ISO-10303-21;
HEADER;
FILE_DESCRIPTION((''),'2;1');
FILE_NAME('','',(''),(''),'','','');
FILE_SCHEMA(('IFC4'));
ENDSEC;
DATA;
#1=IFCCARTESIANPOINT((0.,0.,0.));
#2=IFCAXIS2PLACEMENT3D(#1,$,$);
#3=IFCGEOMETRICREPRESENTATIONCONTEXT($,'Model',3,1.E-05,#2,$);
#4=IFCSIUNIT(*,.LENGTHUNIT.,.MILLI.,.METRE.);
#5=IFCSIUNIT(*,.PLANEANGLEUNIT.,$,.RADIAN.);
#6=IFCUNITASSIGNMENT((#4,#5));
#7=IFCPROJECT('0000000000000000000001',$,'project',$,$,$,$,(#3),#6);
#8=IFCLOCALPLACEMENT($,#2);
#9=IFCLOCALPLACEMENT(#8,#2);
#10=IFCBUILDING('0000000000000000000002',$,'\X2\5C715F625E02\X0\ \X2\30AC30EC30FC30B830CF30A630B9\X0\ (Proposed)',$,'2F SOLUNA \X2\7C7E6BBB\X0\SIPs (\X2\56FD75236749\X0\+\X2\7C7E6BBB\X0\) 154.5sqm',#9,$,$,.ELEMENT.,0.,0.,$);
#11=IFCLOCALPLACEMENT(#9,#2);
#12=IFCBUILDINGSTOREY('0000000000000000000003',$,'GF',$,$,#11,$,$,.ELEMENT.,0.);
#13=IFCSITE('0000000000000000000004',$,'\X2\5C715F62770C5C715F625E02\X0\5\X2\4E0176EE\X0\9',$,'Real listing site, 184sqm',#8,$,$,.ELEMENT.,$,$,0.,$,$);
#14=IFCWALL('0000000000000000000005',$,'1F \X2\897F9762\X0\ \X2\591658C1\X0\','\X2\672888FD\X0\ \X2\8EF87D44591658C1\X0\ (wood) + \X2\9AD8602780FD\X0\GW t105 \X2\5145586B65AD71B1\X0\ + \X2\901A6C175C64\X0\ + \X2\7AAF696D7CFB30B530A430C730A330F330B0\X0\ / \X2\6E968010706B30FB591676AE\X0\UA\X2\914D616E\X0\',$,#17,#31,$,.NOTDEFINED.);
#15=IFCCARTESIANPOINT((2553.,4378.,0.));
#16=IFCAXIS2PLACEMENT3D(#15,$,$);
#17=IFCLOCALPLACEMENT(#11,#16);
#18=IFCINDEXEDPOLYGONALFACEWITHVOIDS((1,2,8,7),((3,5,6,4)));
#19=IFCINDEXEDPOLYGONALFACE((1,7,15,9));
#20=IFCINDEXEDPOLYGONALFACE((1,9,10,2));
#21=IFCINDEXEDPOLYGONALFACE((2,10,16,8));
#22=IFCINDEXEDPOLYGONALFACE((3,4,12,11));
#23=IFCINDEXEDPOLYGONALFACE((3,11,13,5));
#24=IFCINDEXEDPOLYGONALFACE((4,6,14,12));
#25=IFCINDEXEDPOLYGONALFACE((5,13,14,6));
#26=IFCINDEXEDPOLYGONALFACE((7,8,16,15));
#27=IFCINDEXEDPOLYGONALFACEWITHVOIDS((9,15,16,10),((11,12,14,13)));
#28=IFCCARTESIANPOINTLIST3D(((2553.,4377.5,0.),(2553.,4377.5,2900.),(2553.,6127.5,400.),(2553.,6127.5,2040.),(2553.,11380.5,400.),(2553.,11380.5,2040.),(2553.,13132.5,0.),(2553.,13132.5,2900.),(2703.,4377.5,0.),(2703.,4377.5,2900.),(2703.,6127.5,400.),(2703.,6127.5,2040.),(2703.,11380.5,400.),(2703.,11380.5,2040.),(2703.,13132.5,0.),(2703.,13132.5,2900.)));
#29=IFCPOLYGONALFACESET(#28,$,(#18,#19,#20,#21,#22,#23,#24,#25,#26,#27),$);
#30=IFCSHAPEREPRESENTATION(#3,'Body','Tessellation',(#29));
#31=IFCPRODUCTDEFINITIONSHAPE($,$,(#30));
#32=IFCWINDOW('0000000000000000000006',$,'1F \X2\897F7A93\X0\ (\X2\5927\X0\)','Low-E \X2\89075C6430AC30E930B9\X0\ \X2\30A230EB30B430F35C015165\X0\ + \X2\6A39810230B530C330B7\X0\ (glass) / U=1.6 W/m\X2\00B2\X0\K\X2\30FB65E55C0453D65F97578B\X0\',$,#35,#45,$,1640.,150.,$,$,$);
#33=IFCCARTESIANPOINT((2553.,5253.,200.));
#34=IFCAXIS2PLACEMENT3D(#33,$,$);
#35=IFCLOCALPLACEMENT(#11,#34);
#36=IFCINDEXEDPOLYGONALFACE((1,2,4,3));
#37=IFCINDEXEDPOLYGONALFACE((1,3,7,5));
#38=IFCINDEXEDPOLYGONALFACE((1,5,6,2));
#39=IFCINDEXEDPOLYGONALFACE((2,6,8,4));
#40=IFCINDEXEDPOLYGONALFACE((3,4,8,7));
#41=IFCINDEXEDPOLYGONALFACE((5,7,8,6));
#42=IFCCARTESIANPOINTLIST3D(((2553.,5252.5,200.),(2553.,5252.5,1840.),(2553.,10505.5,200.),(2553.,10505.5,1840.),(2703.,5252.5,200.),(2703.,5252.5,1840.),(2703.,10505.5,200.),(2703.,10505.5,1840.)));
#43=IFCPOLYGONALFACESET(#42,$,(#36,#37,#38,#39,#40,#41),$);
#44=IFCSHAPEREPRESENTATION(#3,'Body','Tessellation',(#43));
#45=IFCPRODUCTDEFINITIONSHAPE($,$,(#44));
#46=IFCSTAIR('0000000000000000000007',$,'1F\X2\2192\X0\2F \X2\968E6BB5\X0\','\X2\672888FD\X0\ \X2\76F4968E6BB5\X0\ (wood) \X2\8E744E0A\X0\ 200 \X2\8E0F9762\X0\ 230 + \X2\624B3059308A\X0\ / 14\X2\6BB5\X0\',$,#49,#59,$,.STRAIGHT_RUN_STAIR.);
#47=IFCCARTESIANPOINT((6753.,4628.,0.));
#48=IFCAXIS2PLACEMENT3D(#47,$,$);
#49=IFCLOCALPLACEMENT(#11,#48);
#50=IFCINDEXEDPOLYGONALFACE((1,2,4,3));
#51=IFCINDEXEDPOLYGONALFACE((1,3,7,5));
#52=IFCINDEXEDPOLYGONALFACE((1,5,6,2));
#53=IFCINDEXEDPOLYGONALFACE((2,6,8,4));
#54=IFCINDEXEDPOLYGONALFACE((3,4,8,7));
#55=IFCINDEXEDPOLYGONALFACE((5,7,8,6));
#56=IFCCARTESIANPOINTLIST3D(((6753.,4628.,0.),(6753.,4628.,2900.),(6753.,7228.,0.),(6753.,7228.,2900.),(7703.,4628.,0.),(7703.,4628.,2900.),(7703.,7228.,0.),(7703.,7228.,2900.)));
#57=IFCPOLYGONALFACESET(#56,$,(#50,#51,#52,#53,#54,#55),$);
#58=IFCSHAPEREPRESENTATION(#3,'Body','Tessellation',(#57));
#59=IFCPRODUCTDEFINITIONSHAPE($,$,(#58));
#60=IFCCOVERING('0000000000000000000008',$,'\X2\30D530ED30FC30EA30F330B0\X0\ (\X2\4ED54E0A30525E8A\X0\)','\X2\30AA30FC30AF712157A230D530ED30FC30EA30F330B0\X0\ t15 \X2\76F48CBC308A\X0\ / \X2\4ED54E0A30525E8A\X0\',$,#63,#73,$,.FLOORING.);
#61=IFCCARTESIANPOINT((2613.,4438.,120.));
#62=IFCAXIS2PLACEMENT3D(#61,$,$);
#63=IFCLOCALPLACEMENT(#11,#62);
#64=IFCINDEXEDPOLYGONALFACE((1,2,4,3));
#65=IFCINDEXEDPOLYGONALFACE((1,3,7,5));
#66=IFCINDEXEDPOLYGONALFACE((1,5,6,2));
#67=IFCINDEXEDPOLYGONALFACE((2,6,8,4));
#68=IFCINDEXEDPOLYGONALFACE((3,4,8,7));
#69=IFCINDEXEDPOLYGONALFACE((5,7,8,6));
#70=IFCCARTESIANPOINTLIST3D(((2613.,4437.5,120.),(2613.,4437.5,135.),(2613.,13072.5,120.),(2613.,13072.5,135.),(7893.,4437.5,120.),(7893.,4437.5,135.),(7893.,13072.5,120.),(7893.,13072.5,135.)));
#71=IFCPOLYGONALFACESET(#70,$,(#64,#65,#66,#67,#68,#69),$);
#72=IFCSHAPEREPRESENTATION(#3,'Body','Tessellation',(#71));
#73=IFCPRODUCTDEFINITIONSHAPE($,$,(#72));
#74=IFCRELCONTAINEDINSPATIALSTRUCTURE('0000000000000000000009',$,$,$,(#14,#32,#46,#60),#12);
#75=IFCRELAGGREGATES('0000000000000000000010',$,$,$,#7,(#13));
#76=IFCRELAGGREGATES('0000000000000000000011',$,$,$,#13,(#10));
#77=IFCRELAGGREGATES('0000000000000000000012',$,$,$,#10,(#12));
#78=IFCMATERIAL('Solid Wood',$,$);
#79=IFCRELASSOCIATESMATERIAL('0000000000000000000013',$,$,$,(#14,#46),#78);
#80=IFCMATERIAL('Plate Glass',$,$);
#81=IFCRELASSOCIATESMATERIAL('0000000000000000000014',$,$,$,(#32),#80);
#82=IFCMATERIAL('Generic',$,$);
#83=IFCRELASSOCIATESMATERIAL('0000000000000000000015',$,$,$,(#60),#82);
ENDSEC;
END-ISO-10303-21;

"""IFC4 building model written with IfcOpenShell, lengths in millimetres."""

from ifc_helpers import new_model, si_unit, frame, frame_2d, origin, place, context, project, spatial, rectangle, extrude, material, element, fill, save


model = new_model("IFC4")

# Units and contexts
model_context = context("Model", 3, precision=1e-05, world=origin())
ifc_project = project(units=[si_unit("LENGTHUNIT", "METRE", prefix="MILLI"), si_unit("PLANEANGLEUNIT", "RADIAN")], contexts=[model_context])

# Site, building, storey
site_placement = place(None, origin())
site = spatial("IfcSite", under=ifc_project, at=site_placement, Name="山形県山形市5丁目9", ObjectType="Real listing site, 184sqm", CompositionType="ELEMENT", RefElevation=0.0)
building_placement = place(site_placement, origin())
building = spatial("IfcBuilding", under=site, at=building_placement, Name="山形市 ガレージハウス (Proposed)", ObjectType="2F SOLUNA 籾殻SIPs (国産杉+籾殻) 154.5sqm", CompositionType="ELEMENT", ElevationOfRefHeight=0.0, ElevationOfTerrain=0.0)
storey_placement = place(building_placement, origin())
storey = spatial("IfcBuildingStorey", under=building, at=storey_placement, Name="GF", CompositionType="ELEMENT", Elevation=0.0)

# Shared definitions
ifc_material_1 = material(Name="Solid Wood")
ifc_material_2 = material(Name="Generic")

# Shared definitions
ifc_material_3 = material(Name="Plate Glass")

# Wall, opening, window
wall_1_placement = place(storey_placement, frame((2553.0, 4378.0, 0.0)))
wall_1 = element("IfcWall", 1, at=wall_1_placement, inside=storey, material=ifc_material_1, Name="1F 西面 外壁", Description="木製 軸組外壁 (wood) + 高性能GW t105 充填断熱 + 通気層 + 窯業系サイディング / 準耐火・外皮UA配慮", PredefinedType="NOTDEFINED", context=model_context, shape_type="SweptSolid", body=[
    extrude(rectangle(XDim=150.0, YDim=8755.0, at=frame_2d((75.0, 4377.0))), frame((2553.0, 4378.0, 0.0)), (0.0, 0.0, 1.0), 2900.0),
])
opening_1_placement = place(storey_placement, frame((2553.0, 5253.0, 200.0)))
opening_1 = element("IfcOpeningElement", 2, at=opening_1_placement, cuts=wall_1, PredefinedType="NOTDEFINED", context=model_context, shape_type="SweptSolid", body=[
    extrude(rectangle(XDim=150.0, YDim=5253.0, at=frame_2d((75.0, 2626.0))), frame((2553.0, 5253.0, 200.0)), (0.0, 0.0, 1.0), 1640.0),
])
window_1_placement = place(storey_placement, frame((2553.0, 5253.0, 200.0)))
window_1 = element("IfcWindow", 3, at=window_1_placement, inside=storey, material=ifc_material_3, Name="1F 西窓 (大)", Description="Low-E 複層ガラス アルゴン封入 + 樹脂サッシ (glass) / U=1.6 W/m²K・日射取得型", OverallHeight=1640.0, OverallWidth=150.0, context=model_context, shape_type="SweptSolid", body=[
    extrude(rectangle(XDim=150.0, YDim=5253.0, at=frame_2d((75.0, 2626.0))), frame((2553.0, 5253.0, 200.0)), (0.0, 0.0, 1.0), 1640.0),
])
fill(opening_1, window_1)

# Stair
stair_placement = place(storey_placement, frame((6753.0, 4628.0, 0.0)))
element("IfcStair", 4, at=stair_placement, inside=storey, material=ifc_material_1, Name="1F→2F 階段", Description="木製 直階段 (wood) 蹴上 200 踏面 230 + 手すり / 14段", PredefinedType="STRAIGHT_RUN_STAIR", context=model_context, shape_type="SweptSolid", body=[
    extrude(rectangle(XDim=950.0, YDim=2600.0, at=frame_2d((475.0, 1300.0))), frame((6753.0, 4628.0, 0.0)), (0.0, 0.0, 1.0), 2900.0),
])

# Covering
covering_placement = place(storey_placement, frame((2613.0, 4438.0, 120.0)))
element("IfcCovering", 5, at=covering_placement, inside=storey, material=ifc_material_2, Name="フローリング (仕上げ床)", Description="オーク無垢フローリング t15 直貼り / 仕上げ床", PredefinedType="FLOORING", context=model_context, shape_type="SweptSolid", body=[
    extrude(rectangle(XDim=5280.0, YDim=8635.0, at=frame_2d((2640.0, 4317.0))), frame((2613.0, 4438.0, 120.0)), (0.0, 0.0, 1.0), 15.0),
])

save(model, "model.ifc")
